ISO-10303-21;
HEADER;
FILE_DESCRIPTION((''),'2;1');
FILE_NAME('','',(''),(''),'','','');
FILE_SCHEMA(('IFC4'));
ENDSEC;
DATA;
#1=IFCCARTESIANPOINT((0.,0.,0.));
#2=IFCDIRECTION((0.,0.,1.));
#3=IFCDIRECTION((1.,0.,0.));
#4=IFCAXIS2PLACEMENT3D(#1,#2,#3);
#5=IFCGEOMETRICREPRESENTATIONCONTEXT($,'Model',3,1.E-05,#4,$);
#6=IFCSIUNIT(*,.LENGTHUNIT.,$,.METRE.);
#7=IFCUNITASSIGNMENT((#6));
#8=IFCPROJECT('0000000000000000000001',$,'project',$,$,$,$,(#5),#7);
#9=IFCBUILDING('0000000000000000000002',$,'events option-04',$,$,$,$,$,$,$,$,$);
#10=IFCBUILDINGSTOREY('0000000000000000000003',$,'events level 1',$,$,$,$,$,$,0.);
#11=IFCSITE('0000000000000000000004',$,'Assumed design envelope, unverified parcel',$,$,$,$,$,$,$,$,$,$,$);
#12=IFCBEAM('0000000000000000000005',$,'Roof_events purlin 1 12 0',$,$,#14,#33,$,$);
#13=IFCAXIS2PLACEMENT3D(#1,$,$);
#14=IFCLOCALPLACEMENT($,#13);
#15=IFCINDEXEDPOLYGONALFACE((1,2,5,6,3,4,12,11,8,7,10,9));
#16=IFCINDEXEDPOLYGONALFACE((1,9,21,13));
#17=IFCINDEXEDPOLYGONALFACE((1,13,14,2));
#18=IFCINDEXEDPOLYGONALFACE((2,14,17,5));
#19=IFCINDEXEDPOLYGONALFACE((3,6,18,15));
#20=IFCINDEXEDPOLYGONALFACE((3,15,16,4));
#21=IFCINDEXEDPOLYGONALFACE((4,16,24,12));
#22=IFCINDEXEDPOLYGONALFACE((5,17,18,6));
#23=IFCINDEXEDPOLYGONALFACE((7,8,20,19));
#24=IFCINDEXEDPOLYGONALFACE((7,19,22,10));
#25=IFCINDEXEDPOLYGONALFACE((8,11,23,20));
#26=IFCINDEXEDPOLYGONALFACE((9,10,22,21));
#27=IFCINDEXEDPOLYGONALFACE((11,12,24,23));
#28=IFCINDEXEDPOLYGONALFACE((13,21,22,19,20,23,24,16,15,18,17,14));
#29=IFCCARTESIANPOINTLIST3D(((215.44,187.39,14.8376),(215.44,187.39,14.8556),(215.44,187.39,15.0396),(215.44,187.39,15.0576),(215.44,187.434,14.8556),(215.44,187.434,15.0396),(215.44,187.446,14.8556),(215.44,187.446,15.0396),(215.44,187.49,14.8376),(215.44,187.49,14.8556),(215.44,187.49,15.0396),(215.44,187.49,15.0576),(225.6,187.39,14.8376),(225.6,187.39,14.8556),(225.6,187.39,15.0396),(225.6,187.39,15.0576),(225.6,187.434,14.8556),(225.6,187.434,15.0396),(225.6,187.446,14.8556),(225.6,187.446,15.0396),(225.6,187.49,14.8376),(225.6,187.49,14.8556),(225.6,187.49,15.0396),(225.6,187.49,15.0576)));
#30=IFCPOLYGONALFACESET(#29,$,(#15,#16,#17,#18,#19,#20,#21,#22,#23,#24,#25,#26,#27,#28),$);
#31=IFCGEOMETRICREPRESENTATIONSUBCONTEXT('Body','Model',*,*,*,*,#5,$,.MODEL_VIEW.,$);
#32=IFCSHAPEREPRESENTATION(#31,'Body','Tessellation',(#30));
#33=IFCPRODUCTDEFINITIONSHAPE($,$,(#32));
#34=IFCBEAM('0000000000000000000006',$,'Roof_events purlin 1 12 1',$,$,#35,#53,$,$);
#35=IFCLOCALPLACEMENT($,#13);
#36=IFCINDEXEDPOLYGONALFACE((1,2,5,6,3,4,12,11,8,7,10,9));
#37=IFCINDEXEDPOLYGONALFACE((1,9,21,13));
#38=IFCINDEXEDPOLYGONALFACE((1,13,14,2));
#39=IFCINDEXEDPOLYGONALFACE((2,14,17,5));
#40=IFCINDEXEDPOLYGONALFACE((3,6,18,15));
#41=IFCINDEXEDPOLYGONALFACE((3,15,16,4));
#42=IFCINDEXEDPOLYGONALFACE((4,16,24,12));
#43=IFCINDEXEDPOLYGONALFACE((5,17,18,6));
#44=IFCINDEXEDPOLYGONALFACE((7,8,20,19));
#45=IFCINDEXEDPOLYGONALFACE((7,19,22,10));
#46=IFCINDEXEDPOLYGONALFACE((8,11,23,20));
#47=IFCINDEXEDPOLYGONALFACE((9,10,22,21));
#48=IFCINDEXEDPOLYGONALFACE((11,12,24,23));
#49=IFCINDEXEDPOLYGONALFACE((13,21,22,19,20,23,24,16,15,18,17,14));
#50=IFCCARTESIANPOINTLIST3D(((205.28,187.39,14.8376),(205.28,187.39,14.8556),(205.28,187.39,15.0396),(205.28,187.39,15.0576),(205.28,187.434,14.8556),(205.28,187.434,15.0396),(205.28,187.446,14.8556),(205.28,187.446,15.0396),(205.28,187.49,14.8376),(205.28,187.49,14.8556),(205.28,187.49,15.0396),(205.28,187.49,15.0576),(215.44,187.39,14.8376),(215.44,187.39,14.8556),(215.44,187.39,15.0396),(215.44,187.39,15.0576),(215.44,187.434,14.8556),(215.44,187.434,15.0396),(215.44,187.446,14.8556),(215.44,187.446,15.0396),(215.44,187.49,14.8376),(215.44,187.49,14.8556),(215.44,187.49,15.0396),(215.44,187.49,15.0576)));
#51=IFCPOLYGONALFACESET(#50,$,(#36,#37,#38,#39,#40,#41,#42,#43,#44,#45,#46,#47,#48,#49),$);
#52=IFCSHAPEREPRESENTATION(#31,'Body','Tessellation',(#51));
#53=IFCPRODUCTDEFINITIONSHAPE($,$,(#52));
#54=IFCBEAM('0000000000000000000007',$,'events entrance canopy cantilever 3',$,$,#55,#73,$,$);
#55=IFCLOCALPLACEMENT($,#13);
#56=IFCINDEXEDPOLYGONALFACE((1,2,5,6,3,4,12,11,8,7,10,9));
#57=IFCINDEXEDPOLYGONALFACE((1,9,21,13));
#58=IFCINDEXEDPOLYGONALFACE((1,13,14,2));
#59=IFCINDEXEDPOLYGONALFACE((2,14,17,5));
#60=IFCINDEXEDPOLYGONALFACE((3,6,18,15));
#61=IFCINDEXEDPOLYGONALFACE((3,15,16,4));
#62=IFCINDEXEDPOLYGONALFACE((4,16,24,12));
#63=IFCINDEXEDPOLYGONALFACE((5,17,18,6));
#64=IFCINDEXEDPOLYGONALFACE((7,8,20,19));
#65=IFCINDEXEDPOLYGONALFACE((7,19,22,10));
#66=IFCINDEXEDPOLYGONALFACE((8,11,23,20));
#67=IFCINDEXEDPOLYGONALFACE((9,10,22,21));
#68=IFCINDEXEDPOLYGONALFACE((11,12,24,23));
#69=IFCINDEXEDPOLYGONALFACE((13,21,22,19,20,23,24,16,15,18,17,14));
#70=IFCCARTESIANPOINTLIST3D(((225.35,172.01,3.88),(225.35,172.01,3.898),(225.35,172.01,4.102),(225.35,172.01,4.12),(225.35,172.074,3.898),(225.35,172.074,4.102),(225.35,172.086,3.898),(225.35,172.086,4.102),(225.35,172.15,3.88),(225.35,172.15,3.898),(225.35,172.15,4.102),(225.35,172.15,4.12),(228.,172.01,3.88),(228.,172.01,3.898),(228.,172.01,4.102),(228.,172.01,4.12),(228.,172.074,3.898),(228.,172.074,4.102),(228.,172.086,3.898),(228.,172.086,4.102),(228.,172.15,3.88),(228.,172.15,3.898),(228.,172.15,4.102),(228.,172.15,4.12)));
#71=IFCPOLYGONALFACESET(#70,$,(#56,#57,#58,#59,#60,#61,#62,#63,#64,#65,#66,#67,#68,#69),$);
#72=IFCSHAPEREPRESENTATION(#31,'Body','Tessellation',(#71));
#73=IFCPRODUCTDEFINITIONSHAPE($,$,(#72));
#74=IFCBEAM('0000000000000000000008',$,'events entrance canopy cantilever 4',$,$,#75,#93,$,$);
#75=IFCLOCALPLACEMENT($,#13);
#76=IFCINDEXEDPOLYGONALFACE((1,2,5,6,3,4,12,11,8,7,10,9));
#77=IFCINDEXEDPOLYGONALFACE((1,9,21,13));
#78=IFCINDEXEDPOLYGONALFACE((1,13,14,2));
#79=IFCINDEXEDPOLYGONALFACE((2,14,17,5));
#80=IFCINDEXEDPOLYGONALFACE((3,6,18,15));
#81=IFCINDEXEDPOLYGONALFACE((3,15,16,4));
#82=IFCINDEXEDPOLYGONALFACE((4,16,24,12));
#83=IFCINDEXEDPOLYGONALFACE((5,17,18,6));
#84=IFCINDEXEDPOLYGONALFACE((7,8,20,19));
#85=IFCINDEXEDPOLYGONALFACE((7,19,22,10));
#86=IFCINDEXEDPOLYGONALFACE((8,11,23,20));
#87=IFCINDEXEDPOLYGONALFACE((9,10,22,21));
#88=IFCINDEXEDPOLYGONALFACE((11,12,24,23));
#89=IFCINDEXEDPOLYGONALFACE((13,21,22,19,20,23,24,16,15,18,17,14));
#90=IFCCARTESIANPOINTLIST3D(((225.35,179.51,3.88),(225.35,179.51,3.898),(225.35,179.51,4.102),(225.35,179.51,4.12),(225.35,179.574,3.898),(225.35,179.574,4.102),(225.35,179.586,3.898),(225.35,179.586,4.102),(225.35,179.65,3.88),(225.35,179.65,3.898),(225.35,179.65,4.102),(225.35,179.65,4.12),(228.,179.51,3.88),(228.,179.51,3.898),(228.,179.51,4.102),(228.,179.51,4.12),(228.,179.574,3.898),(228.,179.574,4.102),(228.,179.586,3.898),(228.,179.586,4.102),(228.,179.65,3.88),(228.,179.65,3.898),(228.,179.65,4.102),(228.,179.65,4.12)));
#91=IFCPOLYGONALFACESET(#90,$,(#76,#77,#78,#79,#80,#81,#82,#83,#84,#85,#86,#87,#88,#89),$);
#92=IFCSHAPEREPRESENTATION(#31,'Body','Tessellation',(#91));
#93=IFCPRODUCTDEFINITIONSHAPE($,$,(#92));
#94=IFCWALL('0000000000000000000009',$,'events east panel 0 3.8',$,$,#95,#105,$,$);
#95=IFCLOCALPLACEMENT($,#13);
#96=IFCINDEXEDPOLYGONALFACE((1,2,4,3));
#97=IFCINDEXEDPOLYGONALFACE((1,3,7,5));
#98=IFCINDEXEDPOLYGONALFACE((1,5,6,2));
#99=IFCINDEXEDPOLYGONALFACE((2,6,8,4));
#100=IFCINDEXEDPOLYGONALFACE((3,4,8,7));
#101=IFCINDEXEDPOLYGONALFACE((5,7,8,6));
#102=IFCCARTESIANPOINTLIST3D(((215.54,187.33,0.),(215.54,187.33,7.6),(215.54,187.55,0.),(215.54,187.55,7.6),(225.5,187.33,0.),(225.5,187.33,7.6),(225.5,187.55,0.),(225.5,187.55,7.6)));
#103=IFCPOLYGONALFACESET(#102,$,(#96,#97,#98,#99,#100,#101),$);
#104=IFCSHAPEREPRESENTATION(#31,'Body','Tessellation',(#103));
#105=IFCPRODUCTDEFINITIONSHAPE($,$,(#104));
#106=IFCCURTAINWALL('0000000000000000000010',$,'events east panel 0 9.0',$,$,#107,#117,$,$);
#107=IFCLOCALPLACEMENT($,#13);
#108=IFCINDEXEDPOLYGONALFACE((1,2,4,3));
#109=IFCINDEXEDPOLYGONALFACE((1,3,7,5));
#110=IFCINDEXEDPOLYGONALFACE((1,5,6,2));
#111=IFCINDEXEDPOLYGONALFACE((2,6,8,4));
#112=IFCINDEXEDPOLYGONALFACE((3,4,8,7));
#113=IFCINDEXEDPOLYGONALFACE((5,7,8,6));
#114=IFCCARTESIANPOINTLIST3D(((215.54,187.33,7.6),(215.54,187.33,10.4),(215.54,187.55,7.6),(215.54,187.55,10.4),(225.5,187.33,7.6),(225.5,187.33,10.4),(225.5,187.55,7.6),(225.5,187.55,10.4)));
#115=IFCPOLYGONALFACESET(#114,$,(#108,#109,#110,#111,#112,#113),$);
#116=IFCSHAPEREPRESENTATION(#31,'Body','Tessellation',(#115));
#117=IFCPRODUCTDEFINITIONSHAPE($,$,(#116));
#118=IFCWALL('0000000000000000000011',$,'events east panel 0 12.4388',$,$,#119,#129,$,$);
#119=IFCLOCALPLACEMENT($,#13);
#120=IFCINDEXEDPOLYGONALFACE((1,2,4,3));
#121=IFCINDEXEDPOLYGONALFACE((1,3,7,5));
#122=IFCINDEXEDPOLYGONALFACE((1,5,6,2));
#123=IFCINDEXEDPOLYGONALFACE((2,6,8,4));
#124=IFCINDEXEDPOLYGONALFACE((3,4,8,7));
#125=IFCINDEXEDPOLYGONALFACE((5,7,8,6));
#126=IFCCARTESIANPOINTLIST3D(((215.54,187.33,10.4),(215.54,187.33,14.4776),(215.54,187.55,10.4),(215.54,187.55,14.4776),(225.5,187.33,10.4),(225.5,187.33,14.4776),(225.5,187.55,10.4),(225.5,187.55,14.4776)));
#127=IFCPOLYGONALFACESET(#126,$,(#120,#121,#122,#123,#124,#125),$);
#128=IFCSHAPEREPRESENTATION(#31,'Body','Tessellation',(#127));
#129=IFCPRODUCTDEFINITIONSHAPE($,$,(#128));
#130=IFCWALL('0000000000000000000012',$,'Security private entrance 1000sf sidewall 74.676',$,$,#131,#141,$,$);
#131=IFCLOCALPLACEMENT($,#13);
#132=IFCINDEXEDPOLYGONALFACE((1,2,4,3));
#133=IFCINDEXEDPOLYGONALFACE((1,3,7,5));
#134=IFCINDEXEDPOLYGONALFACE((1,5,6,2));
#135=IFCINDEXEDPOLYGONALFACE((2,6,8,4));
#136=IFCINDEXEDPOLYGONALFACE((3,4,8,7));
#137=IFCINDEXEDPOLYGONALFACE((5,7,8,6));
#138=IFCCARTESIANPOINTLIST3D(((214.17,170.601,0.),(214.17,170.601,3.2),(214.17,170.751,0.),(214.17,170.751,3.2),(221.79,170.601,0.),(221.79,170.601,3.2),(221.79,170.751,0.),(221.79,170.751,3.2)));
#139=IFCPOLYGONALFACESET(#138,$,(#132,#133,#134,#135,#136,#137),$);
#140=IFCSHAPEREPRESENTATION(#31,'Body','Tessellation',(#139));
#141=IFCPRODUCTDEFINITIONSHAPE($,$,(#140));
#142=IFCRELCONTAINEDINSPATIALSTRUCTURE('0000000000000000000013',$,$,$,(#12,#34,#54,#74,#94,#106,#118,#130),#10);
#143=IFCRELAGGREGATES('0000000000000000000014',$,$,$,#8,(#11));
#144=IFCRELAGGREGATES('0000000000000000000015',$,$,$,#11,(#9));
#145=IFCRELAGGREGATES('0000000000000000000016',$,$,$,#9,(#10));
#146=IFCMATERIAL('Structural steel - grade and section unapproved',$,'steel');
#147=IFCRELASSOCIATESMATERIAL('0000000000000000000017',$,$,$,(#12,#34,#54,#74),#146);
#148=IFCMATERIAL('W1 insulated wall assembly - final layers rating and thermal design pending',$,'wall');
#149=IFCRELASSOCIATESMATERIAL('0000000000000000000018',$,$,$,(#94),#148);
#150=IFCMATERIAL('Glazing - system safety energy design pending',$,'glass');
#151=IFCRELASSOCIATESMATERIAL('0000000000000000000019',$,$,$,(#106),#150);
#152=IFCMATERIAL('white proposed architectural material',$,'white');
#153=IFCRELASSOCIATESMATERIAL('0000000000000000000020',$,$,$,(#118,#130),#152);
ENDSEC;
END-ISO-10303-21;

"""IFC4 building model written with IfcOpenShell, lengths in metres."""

from ifc_helpers import new_model, si_unit, frame, origin_with_axes, place, context, subcontext, project, spatial, rectangle, i_section, extrude, material, element, save


model = new_model("IFC4")

# Units and contexts
model_context = context("Model", 3, precision=1e-05, world=origin_with_axes())
body_context = subcontext(model_context, "Body", "Model", "MODEL_VIEW")
ifc_project = project(units=[si_unit("LENGTHUNIT", "METRE")], contexts=[model_context])

# Site, building, storey
site = spatial("IfcSite", under=ifc_project, Name="Assumed design envelope, unverified parcel")
building = spatial("IfcBuilding", under=site, Name="events option-04")
storey = spatial("IfcBuildingStorey", under=building, Name="events level 1", Elevation=0.0)

# Shared definitions
ifc_material_1 = material(Name="Structural steel - grade and section unapproved", Category="steel")

# Beams
for number, where, z_axis, x_axis, name in (
    (1, (225.6, 187.44, 14.9476), (-1.0, 0.0, 0.0), (0.0, -1.0, 0.0), "Roof_events purlin 1 12 0"),
    (2, (215.44, 187.44, 14.9476), (-1.0, 0.0, 0.0), (0.0, -1.0, 0.0), "Roof_events purlin 1 12 1"),
):
    element("IfcBeam", number, at=place(None, frame(where, z_axis=z_axis, x_axis=x_axis)), inside=storey, material=ifc_material_1, Name=name, context=body_context, shape_type="SweptSolid", body=[
        extrude(i_section(OverallWidth=0.1, OverallDepth=0.22, WebThickness=0.012, FlangeThickness=0.018, FilletRadius=0.0), origin_with_axes(), (0.0, 0.0, 1.0), 10.16),
    ])
for number, where, z_axis, x_axis, name in (
    (3, (225.35, 172.08, 4.0), (1.0, 0.0, 0.0), (0.0, 1.0, 0.0), "events entrance canopy cantilever 3"),
    (4, (225.35, 179.58, 4.0), (1.0, 0.0, 0.0), (0.0, 1.0, 0.0), "events entrance canopy cantilever 4"),
):
    element("IfcBeam", number, at=place(None, frame(where, z_axis=z_axis, x_axis=x_axis)), inside=storey, material=ifc_material_1, Name=name, context=body_context, shape_type="SweptSolid", body=[
        extrude(i_section(OverallWidth=0.14, OverallDepth=0.24, WebThickness=0.012, FlangeThickness=0.018, FilletRadius=0.0), origin_with_axes(), (0.0, 0.0, 1.0), 2.65),
    ])

# Wall
ifc_material_2 = material(Name="W1 insulated wall assembly - final layers rating and thermal design pending", Category="wall")
wall_1_placement = place(None, frame((220.52, 187.44, 0.0), z_axis=(0.0, 0.0, 1.0), x_axis=(0.0, 1.0, 0.0)))
element("IfcWall", 5, at=wall_1_placement, inside=storey, material=ifc_material_2, Name="events east panel 0 3.8", context=body_context, shape_type="SweptSolid", body=[
    extrude(rectangle(XDim=0.22, YDim=9.96), origin_with_axes(), (0.0, 0.0, 1.0), 7.6),
])

# Curtain wall
ifc_material_3 = material(Name="Glazing - system safety energy design pending", Category="glass")
curtain_wall_placement = place(None, frame((220.52, 187.44, 7.6), z_axis=(0.0, 0.0, 1.0), x_axis=(0.0, 1.0, 0.0)))
element("IfcCurtainWall", 6, at=curtain_wall_placement, inside=storey, material=ifc_material_3, Name="events east panel 0 9.0", context=body_context, shape_type="SweptSolid", body=[
    extrude(rectangle(XDim=0.22, YDim=9.96), origin_with_axes(), (0.0, 0.0, 1.0), 2.8),
])

# Walls
ifc_material_4 = material(Name="white proposed architectural material", Category="white")
wall_2_placement = place(None, frame((220.52, 187.44, 10.4), z_axis=(0.0, 0.0, 1.0), x_axis=(0.0, 1.0, 0.0)))
element("IfcWall", 7, at=wall_2_placement, inside=storey, material=ifc_material_4, Name="events east panel 0 12.4388", context=body_context, shape_type="SweptSolid", body=[
    extrude(rectangle(XDim=0.22, YDim=9.96), origin_with_axes(), (0.0, 0.0, 1.0), 4.0776),
])
wall_3_placement = place(None, frame((217.98, 170.676, 0.0), z_axis=(0.0, 0.0, 1.0), x_axis=(0.0, 1.0, 0.0)))
element("IfcWall", 8, at=wall_3_placement, inside=storey, material=ifc_material_4, Name="Security private entrance 1000sf sidewall 74.676", context=body_context, shape_type="SweptSolid", body=[
    extrude(rectangle(XDim=0.15, YDim=7.62), origin_with_axes(), (0.0, 0.0, 1.0), 3.2),
])

save(model, "model.ifc")
